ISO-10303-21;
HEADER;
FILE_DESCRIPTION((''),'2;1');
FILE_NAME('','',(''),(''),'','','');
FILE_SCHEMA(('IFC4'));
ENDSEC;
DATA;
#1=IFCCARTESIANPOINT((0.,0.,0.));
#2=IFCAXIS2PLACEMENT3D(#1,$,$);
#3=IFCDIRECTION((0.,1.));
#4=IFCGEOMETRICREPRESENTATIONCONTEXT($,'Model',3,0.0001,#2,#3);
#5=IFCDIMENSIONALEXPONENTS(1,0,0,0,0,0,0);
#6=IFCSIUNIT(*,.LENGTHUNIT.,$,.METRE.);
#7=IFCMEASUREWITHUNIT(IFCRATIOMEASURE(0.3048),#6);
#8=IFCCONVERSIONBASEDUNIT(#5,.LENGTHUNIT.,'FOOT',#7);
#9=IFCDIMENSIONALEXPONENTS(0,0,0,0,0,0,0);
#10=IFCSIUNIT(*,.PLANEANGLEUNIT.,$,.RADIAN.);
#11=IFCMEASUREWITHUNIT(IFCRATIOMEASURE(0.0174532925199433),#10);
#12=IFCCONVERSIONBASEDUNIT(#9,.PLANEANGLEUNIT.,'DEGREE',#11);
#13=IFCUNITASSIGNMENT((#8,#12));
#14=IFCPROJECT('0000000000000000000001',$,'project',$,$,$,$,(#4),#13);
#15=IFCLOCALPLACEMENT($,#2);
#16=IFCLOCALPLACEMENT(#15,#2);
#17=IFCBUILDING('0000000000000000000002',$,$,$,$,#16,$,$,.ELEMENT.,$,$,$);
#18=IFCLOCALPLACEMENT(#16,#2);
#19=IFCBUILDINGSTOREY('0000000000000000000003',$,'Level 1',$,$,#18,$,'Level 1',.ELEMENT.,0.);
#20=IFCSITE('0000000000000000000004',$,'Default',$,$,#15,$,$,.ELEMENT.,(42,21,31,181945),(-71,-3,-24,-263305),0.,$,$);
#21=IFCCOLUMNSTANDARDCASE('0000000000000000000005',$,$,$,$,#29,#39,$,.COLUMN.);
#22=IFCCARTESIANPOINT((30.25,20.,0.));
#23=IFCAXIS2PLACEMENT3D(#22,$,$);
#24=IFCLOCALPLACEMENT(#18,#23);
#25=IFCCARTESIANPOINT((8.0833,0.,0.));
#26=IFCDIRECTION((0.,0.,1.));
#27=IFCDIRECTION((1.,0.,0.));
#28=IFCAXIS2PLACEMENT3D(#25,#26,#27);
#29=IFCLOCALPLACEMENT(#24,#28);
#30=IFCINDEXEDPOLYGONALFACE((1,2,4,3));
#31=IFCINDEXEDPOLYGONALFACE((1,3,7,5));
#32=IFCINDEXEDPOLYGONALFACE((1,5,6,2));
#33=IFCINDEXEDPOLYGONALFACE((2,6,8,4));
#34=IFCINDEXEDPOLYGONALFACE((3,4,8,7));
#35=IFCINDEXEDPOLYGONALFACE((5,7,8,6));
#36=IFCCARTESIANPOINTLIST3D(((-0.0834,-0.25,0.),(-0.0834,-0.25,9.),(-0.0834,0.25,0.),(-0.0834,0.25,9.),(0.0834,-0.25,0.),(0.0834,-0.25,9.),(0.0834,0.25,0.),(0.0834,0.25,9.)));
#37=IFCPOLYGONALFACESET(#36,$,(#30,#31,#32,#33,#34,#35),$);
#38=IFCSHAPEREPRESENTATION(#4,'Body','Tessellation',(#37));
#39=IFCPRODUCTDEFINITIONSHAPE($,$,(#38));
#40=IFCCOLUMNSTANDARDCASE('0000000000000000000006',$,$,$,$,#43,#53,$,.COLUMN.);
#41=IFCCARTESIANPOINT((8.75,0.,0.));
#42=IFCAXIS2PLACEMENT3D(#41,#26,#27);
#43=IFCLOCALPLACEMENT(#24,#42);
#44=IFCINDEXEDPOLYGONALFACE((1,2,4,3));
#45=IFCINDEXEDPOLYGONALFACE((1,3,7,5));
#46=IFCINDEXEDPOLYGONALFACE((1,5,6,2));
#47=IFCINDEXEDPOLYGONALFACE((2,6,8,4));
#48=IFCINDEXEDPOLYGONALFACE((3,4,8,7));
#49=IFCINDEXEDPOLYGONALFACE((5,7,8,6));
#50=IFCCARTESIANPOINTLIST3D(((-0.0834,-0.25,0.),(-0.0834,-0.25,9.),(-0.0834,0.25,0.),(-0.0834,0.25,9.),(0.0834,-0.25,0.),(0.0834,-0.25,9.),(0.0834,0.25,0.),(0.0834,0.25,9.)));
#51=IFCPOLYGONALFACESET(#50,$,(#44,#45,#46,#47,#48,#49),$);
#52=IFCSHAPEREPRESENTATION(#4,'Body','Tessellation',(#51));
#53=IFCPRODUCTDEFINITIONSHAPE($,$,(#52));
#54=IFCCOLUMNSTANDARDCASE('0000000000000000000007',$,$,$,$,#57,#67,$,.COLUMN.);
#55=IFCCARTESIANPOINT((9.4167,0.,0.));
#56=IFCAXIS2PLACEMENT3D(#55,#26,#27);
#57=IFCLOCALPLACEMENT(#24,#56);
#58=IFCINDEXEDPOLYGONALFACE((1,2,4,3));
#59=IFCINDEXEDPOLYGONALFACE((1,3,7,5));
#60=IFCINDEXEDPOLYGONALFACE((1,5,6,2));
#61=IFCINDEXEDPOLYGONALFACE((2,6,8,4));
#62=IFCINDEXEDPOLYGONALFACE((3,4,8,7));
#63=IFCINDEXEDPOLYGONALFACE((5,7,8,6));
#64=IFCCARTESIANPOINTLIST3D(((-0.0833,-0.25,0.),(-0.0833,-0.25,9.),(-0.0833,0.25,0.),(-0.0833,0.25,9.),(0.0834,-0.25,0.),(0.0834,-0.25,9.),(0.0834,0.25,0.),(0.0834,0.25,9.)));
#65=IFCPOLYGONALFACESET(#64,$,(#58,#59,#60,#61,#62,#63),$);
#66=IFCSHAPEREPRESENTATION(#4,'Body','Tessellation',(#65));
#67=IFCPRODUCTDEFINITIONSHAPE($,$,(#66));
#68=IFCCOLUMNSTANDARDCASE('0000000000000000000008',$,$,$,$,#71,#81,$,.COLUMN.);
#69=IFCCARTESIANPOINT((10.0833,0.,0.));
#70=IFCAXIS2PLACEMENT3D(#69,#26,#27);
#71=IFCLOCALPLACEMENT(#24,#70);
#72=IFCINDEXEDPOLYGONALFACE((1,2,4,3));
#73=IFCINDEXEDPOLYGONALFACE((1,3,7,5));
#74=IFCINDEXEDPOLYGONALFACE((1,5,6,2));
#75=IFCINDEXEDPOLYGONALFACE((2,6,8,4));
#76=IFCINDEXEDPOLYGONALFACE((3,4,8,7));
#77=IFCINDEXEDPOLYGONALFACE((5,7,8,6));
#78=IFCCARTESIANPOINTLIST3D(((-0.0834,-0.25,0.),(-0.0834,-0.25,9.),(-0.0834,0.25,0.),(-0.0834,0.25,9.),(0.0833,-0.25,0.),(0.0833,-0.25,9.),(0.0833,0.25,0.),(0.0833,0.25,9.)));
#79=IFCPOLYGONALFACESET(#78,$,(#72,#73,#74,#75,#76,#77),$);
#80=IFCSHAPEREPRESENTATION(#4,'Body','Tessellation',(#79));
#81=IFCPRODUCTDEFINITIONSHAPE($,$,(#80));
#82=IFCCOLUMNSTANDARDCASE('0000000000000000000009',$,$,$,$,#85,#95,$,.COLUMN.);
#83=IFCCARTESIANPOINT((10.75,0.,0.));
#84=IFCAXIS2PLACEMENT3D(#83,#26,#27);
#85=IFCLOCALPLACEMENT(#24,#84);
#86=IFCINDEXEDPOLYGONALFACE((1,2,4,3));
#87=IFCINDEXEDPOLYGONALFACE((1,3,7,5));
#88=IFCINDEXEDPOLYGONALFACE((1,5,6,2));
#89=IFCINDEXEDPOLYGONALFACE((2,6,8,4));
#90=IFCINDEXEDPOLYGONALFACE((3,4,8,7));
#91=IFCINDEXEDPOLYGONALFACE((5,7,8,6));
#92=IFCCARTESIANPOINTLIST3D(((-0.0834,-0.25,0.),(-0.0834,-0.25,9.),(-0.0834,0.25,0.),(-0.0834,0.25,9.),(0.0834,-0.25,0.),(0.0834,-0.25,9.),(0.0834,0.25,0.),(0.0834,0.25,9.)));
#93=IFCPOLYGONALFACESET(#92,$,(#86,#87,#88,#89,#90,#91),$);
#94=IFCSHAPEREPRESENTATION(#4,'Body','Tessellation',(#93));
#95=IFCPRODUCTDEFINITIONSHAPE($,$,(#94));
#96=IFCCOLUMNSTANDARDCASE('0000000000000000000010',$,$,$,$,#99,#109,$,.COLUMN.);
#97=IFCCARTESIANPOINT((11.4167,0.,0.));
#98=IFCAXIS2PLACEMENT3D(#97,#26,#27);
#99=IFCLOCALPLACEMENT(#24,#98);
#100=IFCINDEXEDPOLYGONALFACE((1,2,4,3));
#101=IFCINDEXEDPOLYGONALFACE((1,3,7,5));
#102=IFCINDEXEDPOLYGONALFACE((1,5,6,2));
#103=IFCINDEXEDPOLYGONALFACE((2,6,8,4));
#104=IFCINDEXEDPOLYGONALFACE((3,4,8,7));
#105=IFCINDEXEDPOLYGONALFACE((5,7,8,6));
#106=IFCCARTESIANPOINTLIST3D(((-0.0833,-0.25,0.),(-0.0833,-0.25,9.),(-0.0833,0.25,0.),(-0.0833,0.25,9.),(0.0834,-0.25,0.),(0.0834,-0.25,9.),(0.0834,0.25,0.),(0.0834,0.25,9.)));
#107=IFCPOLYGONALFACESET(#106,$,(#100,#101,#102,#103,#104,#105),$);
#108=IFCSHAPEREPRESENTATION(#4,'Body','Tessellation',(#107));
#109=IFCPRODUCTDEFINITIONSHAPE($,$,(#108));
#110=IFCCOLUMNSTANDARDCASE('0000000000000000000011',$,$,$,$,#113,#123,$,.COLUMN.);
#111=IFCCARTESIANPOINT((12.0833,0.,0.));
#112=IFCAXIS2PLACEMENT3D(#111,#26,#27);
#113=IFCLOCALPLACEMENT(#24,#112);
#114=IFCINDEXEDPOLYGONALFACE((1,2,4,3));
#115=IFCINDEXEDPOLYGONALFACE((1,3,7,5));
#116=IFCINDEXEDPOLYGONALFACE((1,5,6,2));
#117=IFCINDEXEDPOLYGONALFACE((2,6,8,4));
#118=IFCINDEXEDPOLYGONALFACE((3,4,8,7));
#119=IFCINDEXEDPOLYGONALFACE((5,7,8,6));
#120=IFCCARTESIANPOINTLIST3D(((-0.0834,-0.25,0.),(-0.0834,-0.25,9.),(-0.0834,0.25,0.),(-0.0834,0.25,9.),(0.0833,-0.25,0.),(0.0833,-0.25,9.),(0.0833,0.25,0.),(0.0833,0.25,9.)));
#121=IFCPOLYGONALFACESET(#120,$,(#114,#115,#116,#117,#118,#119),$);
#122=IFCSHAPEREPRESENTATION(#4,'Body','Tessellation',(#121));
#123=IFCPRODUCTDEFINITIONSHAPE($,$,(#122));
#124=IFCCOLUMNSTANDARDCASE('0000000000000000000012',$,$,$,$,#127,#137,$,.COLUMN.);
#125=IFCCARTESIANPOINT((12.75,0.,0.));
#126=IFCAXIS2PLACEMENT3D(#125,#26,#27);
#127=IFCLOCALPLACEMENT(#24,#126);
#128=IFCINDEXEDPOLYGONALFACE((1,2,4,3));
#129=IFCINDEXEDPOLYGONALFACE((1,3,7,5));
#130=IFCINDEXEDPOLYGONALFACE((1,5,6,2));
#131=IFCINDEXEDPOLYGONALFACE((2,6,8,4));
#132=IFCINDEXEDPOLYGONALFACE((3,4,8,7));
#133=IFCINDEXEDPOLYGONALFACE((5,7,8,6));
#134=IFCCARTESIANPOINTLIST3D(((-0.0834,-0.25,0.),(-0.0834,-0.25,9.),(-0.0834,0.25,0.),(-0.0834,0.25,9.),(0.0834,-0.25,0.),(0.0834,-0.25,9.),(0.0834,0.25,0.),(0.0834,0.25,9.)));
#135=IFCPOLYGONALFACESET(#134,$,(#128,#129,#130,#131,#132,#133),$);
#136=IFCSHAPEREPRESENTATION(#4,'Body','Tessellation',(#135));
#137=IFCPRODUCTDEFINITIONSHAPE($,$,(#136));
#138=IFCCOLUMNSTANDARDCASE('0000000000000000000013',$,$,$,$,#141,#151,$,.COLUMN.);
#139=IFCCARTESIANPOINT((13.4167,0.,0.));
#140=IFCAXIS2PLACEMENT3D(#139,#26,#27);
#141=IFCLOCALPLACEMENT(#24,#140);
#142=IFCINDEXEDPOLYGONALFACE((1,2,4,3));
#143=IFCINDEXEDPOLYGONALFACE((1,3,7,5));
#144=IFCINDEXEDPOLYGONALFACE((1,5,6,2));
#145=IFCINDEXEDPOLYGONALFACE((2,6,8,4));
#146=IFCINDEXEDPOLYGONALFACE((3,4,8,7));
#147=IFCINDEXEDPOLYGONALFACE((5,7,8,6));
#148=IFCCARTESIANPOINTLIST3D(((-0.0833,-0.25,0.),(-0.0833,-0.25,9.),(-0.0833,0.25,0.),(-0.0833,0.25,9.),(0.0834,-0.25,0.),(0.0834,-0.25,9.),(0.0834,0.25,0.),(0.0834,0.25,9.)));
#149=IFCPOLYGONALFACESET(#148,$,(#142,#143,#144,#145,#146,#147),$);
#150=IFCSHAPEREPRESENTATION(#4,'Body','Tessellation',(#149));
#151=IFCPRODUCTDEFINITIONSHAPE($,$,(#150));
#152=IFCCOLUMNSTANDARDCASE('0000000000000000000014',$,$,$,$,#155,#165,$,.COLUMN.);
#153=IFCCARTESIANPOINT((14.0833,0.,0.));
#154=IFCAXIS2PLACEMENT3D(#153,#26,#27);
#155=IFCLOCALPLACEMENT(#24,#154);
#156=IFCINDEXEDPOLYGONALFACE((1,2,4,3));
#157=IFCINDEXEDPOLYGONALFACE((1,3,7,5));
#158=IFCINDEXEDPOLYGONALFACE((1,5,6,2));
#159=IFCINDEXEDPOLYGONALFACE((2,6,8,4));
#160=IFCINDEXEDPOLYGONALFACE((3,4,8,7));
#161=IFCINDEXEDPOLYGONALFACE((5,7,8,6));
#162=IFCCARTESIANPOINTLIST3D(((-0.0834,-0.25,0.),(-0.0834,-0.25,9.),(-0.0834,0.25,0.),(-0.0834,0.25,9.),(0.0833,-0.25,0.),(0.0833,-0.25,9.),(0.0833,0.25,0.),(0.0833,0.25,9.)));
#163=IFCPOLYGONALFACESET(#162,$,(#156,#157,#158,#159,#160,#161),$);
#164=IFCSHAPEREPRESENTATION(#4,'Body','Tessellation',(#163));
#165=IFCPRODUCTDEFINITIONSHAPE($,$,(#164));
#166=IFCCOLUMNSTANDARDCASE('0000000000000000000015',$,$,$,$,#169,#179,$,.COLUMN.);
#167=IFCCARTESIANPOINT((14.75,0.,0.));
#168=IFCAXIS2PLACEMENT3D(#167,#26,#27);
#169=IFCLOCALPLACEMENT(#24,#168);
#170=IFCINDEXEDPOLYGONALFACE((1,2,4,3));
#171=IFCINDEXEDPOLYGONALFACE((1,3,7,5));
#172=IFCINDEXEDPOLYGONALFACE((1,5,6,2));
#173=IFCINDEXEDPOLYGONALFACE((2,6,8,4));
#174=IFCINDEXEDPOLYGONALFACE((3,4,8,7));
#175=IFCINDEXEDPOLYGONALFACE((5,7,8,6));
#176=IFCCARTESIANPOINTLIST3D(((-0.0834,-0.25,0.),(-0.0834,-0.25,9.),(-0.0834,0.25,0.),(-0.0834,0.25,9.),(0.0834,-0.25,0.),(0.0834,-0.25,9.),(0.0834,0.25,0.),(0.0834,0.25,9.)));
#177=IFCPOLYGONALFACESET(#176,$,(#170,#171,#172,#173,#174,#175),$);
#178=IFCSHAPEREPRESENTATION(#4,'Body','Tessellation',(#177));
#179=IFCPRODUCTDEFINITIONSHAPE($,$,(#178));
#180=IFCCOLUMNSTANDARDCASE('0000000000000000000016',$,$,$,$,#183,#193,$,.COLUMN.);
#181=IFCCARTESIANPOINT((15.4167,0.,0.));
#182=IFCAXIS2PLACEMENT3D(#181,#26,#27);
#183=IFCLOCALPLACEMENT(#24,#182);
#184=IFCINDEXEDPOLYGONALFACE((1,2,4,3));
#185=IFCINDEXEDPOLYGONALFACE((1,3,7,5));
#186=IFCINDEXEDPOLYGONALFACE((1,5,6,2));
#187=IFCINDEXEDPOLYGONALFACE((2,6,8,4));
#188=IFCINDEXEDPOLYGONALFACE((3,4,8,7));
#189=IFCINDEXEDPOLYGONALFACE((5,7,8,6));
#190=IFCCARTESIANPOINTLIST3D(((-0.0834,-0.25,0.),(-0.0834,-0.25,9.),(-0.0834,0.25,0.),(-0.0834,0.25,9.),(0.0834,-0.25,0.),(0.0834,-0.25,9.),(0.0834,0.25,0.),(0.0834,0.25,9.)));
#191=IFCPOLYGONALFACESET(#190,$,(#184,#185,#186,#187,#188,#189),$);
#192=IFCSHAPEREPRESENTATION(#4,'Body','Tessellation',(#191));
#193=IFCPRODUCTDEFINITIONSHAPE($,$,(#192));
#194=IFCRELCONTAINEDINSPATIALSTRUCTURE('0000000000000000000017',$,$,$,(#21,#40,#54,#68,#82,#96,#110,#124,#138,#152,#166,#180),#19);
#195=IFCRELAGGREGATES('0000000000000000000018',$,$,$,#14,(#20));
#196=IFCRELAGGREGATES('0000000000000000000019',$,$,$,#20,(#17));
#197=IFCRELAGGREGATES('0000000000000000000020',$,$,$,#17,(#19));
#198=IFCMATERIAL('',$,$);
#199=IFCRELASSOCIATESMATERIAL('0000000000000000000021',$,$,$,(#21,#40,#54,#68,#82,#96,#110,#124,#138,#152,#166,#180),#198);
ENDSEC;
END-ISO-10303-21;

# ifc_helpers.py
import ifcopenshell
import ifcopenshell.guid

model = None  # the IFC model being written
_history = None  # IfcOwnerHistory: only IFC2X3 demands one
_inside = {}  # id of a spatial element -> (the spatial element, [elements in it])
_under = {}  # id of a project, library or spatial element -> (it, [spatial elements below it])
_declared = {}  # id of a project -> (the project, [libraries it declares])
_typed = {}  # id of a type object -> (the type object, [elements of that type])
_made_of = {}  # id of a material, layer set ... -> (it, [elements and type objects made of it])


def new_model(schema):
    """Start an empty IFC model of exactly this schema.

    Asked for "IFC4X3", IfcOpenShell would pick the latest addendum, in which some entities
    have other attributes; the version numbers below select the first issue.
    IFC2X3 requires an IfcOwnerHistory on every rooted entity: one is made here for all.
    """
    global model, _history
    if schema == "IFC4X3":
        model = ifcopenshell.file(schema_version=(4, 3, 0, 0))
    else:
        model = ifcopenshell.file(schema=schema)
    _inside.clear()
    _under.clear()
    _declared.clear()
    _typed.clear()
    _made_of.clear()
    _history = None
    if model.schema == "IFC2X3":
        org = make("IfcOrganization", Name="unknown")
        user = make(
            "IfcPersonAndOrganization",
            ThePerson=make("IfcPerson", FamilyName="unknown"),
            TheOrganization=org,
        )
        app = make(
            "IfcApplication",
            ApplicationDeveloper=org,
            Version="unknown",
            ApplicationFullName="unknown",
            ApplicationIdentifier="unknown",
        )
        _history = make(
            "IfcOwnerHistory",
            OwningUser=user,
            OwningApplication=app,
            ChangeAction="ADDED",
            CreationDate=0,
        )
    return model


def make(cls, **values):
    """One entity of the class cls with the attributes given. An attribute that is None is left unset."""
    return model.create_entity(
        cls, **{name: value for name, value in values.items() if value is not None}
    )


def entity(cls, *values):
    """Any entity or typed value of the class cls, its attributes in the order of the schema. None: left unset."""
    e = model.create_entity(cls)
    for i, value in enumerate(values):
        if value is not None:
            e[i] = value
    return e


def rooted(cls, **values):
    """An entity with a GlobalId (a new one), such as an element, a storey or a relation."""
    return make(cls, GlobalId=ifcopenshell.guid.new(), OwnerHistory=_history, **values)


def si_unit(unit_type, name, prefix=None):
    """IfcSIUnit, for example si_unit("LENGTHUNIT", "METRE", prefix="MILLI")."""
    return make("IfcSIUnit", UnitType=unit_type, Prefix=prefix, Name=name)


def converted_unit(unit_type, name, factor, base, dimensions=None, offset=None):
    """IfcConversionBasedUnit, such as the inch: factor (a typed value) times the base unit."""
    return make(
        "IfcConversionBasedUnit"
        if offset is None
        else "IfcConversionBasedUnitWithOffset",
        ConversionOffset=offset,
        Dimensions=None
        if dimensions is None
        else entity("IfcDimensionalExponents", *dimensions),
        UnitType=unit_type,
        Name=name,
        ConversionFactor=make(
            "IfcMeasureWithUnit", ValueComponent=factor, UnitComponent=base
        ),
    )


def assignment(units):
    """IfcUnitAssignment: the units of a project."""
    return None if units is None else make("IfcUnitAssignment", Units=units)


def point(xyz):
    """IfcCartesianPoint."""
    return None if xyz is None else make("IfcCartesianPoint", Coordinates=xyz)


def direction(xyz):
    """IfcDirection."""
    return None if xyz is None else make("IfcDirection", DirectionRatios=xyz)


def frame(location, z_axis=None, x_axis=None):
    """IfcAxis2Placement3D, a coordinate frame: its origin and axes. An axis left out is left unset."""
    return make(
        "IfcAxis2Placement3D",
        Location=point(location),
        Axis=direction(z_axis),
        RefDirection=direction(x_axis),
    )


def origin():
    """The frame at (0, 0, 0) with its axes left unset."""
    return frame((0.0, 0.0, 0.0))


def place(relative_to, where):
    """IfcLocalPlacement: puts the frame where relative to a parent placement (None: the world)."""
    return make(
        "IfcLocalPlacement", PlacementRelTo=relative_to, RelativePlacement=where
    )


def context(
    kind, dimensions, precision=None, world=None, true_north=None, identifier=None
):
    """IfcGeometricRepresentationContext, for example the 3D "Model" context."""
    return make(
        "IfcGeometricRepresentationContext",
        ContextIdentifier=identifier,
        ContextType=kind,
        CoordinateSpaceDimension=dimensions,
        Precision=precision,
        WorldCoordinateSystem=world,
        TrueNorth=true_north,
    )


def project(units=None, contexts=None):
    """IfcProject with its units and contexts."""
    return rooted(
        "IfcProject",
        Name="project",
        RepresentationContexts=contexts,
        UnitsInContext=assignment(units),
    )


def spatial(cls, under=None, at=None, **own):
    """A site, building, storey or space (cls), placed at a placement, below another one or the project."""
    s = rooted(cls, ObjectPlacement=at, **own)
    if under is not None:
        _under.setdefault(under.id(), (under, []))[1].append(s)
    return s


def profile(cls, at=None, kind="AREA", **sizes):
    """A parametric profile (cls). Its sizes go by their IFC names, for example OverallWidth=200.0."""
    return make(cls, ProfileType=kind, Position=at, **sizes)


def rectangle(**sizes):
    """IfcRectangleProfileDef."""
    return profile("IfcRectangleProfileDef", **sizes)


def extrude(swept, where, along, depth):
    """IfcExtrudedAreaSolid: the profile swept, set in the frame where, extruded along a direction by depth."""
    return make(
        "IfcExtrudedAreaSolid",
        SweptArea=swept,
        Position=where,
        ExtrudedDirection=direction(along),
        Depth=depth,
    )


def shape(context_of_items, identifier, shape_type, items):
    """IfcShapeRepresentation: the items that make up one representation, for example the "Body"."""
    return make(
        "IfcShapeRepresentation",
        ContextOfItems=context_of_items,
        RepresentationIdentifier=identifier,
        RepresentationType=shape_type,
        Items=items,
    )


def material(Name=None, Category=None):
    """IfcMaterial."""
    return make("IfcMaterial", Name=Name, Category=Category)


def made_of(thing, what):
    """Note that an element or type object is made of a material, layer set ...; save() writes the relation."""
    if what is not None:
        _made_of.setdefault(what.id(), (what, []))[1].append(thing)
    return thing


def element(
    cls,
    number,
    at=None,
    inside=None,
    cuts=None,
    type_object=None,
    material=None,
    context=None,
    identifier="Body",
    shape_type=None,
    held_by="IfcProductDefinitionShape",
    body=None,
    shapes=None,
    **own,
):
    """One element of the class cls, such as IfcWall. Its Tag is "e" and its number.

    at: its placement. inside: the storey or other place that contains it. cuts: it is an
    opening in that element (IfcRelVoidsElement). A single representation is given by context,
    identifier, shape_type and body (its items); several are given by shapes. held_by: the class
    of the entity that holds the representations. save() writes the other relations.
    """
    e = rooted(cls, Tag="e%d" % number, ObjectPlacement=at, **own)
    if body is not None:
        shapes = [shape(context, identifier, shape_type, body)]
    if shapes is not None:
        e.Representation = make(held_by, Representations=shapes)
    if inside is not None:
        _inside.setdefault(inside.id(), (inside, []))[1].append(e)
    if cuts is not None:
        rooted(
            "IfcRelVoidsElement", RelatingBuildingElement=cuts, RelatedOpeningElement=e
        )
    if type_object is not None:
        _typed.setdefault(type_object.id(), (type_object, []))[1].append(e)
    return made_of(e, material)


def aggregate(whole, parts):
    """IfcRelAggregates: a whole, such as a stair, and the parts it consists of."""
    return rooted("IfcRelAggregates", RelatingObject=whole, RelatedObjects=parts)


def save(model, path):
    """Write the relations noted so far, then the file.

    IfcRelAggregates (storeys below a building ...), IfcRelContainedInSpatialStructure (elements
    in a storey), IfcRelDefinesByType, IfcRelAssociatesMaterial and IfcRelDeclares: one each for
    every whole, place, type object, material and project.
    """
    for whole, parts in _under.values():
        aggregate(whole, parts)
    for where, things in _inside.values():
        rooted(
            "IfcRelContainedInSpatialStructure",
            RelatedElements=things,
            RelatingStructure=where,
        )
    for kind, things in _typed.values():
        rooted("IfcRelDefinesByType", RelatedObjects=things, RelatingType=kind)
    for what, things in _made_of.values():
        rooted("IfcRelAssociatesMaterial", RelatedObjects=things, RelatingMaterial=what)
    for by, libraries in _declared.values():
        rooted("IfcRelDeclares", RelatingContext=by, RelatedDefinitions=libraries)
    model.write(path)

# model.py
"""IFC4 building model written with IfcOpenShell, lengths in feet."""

from ifc_helpers import new_model, entity, si_unit, converted_unit, direction, frame, origin, place, context, project, spatial, rectangle, extrude, material, element, save


model = new_model("IFC4")

# Units and contexts
model_context = context("Model", 3, precision=0.0001, world=origin(), true_north=direction((0.0, 1.0)))
ifc_project = project(units=[converted_unit("LENGTHUNIT", "FOOT", entity("IfcRatioMeasure", 0.3048), si_unit("LENGTHUNIT", "METRE"), dimensions=[1, 0, 0, 0, 0, 0, 0]), converted_unit("PLANEANGLEUNIT", "DEGREE", entity("IfcRatioMeasure", 0.0174532925199433), si_unit("PLANEANGLEUNIT", "RADIAN"), dimensions=[0, 0, 0, 0, 0, 0, 0])], contexts=[model_context])

# Site, building, storey
site_placement = place(None, origin())
site = spatial("IfcSite", under=ifc_project, at=site_placement, Name="Default", CompositionType="ELEMENT", RefLatitude=(42, 21, 31, 181945), RefLongitude=(-71, -3, -24, -263305), RefElevation=0.0)
building_placement = place(site_placement, origin())
building = spatial("IfcBuilding", under=site, at=building_placement, CompositionType="ELEMENT")
storey_placement = place(building_placement, origin())
storey = spatial("IfcBuildingStorey", under=building, at=storey_placement, Name="Level 1", LongName="Level 1", CompositionType="ELEMENT", Elevation=0.0)

# Columns
ifc_material_1 = material(Name="")
placement_1 = place(storey_placement, frame((30.25, 20.0, 0.0)))
for number, where, z_axis, x_axis in (
    (1, (8.0833, 0.0, 0.0), (0.0, 0.0, 1.0), (1.0, 0.0, 0.0)),
    (2, (8.75, 0.0, 0.0), (0.0, 0.0, 1.0), (1.0, 0.0, 0.0)),
    (3, (9.4167, 0.0, 0.0), (0.0, 0.0, 1.0), (1.0, 0.0, 0.0)),
    (4, (10.0833, 0.0, 0.0), (0.0, 0.0, 1.0), (1.0, 0.0, 0.0)),
    (5, (10.75, 0.0, 0.0), (0.0, 0.0, 1.0), (1.0, 0.0, 0.0)),
    (6, (11.4167, 0.0, 0.0), (0.0, 0.0, 1.0), (1.0, 0.0, 0.0)),
    (7, (12.0833, 0.0, 0.0), (0.0, 0.0, 1.0), (1.0, 0.0, 0.0)),
    (8, (12.75, 0.0, 0.0), (0.0, 0.0, 1.0), (1.0, 0.0, 0.0)),
    (9, (13.4167, 0.0, 0.0), (0.0, 0.0, 1.0), (1.0, 0.0, 0.0)),
    (10, (14.0833, 0.0, 0.0), (0.0, 0.0, 1.0), (1.0, 0.0, 0.0)),
    (11, (14.75, 0.0, 0.0), (0.0, 0.0, 1.0), (1.0, 0.0, 0.0)),
    (12, (15.4167, 0.0, 0.0), (0.0, 0.0, 1.0), (1.0, 0.0, 0.0)),
):
    element("IfcColumnStandardCase", number, at=place(placement_1, frame(where, z_axis=z_axis, x_axis=x_axis)), inside=storey, material=ifc_material_1, PredefinedType="COLUMN", context=model_context, shape_type="SweptSolid", body=[
        extrude(rectangle(XDim=0.1667, YDim=0.5), origin(), (0.0, 0.0, 1.0), 9.0),
    ])

save(model, "model.ifc")
